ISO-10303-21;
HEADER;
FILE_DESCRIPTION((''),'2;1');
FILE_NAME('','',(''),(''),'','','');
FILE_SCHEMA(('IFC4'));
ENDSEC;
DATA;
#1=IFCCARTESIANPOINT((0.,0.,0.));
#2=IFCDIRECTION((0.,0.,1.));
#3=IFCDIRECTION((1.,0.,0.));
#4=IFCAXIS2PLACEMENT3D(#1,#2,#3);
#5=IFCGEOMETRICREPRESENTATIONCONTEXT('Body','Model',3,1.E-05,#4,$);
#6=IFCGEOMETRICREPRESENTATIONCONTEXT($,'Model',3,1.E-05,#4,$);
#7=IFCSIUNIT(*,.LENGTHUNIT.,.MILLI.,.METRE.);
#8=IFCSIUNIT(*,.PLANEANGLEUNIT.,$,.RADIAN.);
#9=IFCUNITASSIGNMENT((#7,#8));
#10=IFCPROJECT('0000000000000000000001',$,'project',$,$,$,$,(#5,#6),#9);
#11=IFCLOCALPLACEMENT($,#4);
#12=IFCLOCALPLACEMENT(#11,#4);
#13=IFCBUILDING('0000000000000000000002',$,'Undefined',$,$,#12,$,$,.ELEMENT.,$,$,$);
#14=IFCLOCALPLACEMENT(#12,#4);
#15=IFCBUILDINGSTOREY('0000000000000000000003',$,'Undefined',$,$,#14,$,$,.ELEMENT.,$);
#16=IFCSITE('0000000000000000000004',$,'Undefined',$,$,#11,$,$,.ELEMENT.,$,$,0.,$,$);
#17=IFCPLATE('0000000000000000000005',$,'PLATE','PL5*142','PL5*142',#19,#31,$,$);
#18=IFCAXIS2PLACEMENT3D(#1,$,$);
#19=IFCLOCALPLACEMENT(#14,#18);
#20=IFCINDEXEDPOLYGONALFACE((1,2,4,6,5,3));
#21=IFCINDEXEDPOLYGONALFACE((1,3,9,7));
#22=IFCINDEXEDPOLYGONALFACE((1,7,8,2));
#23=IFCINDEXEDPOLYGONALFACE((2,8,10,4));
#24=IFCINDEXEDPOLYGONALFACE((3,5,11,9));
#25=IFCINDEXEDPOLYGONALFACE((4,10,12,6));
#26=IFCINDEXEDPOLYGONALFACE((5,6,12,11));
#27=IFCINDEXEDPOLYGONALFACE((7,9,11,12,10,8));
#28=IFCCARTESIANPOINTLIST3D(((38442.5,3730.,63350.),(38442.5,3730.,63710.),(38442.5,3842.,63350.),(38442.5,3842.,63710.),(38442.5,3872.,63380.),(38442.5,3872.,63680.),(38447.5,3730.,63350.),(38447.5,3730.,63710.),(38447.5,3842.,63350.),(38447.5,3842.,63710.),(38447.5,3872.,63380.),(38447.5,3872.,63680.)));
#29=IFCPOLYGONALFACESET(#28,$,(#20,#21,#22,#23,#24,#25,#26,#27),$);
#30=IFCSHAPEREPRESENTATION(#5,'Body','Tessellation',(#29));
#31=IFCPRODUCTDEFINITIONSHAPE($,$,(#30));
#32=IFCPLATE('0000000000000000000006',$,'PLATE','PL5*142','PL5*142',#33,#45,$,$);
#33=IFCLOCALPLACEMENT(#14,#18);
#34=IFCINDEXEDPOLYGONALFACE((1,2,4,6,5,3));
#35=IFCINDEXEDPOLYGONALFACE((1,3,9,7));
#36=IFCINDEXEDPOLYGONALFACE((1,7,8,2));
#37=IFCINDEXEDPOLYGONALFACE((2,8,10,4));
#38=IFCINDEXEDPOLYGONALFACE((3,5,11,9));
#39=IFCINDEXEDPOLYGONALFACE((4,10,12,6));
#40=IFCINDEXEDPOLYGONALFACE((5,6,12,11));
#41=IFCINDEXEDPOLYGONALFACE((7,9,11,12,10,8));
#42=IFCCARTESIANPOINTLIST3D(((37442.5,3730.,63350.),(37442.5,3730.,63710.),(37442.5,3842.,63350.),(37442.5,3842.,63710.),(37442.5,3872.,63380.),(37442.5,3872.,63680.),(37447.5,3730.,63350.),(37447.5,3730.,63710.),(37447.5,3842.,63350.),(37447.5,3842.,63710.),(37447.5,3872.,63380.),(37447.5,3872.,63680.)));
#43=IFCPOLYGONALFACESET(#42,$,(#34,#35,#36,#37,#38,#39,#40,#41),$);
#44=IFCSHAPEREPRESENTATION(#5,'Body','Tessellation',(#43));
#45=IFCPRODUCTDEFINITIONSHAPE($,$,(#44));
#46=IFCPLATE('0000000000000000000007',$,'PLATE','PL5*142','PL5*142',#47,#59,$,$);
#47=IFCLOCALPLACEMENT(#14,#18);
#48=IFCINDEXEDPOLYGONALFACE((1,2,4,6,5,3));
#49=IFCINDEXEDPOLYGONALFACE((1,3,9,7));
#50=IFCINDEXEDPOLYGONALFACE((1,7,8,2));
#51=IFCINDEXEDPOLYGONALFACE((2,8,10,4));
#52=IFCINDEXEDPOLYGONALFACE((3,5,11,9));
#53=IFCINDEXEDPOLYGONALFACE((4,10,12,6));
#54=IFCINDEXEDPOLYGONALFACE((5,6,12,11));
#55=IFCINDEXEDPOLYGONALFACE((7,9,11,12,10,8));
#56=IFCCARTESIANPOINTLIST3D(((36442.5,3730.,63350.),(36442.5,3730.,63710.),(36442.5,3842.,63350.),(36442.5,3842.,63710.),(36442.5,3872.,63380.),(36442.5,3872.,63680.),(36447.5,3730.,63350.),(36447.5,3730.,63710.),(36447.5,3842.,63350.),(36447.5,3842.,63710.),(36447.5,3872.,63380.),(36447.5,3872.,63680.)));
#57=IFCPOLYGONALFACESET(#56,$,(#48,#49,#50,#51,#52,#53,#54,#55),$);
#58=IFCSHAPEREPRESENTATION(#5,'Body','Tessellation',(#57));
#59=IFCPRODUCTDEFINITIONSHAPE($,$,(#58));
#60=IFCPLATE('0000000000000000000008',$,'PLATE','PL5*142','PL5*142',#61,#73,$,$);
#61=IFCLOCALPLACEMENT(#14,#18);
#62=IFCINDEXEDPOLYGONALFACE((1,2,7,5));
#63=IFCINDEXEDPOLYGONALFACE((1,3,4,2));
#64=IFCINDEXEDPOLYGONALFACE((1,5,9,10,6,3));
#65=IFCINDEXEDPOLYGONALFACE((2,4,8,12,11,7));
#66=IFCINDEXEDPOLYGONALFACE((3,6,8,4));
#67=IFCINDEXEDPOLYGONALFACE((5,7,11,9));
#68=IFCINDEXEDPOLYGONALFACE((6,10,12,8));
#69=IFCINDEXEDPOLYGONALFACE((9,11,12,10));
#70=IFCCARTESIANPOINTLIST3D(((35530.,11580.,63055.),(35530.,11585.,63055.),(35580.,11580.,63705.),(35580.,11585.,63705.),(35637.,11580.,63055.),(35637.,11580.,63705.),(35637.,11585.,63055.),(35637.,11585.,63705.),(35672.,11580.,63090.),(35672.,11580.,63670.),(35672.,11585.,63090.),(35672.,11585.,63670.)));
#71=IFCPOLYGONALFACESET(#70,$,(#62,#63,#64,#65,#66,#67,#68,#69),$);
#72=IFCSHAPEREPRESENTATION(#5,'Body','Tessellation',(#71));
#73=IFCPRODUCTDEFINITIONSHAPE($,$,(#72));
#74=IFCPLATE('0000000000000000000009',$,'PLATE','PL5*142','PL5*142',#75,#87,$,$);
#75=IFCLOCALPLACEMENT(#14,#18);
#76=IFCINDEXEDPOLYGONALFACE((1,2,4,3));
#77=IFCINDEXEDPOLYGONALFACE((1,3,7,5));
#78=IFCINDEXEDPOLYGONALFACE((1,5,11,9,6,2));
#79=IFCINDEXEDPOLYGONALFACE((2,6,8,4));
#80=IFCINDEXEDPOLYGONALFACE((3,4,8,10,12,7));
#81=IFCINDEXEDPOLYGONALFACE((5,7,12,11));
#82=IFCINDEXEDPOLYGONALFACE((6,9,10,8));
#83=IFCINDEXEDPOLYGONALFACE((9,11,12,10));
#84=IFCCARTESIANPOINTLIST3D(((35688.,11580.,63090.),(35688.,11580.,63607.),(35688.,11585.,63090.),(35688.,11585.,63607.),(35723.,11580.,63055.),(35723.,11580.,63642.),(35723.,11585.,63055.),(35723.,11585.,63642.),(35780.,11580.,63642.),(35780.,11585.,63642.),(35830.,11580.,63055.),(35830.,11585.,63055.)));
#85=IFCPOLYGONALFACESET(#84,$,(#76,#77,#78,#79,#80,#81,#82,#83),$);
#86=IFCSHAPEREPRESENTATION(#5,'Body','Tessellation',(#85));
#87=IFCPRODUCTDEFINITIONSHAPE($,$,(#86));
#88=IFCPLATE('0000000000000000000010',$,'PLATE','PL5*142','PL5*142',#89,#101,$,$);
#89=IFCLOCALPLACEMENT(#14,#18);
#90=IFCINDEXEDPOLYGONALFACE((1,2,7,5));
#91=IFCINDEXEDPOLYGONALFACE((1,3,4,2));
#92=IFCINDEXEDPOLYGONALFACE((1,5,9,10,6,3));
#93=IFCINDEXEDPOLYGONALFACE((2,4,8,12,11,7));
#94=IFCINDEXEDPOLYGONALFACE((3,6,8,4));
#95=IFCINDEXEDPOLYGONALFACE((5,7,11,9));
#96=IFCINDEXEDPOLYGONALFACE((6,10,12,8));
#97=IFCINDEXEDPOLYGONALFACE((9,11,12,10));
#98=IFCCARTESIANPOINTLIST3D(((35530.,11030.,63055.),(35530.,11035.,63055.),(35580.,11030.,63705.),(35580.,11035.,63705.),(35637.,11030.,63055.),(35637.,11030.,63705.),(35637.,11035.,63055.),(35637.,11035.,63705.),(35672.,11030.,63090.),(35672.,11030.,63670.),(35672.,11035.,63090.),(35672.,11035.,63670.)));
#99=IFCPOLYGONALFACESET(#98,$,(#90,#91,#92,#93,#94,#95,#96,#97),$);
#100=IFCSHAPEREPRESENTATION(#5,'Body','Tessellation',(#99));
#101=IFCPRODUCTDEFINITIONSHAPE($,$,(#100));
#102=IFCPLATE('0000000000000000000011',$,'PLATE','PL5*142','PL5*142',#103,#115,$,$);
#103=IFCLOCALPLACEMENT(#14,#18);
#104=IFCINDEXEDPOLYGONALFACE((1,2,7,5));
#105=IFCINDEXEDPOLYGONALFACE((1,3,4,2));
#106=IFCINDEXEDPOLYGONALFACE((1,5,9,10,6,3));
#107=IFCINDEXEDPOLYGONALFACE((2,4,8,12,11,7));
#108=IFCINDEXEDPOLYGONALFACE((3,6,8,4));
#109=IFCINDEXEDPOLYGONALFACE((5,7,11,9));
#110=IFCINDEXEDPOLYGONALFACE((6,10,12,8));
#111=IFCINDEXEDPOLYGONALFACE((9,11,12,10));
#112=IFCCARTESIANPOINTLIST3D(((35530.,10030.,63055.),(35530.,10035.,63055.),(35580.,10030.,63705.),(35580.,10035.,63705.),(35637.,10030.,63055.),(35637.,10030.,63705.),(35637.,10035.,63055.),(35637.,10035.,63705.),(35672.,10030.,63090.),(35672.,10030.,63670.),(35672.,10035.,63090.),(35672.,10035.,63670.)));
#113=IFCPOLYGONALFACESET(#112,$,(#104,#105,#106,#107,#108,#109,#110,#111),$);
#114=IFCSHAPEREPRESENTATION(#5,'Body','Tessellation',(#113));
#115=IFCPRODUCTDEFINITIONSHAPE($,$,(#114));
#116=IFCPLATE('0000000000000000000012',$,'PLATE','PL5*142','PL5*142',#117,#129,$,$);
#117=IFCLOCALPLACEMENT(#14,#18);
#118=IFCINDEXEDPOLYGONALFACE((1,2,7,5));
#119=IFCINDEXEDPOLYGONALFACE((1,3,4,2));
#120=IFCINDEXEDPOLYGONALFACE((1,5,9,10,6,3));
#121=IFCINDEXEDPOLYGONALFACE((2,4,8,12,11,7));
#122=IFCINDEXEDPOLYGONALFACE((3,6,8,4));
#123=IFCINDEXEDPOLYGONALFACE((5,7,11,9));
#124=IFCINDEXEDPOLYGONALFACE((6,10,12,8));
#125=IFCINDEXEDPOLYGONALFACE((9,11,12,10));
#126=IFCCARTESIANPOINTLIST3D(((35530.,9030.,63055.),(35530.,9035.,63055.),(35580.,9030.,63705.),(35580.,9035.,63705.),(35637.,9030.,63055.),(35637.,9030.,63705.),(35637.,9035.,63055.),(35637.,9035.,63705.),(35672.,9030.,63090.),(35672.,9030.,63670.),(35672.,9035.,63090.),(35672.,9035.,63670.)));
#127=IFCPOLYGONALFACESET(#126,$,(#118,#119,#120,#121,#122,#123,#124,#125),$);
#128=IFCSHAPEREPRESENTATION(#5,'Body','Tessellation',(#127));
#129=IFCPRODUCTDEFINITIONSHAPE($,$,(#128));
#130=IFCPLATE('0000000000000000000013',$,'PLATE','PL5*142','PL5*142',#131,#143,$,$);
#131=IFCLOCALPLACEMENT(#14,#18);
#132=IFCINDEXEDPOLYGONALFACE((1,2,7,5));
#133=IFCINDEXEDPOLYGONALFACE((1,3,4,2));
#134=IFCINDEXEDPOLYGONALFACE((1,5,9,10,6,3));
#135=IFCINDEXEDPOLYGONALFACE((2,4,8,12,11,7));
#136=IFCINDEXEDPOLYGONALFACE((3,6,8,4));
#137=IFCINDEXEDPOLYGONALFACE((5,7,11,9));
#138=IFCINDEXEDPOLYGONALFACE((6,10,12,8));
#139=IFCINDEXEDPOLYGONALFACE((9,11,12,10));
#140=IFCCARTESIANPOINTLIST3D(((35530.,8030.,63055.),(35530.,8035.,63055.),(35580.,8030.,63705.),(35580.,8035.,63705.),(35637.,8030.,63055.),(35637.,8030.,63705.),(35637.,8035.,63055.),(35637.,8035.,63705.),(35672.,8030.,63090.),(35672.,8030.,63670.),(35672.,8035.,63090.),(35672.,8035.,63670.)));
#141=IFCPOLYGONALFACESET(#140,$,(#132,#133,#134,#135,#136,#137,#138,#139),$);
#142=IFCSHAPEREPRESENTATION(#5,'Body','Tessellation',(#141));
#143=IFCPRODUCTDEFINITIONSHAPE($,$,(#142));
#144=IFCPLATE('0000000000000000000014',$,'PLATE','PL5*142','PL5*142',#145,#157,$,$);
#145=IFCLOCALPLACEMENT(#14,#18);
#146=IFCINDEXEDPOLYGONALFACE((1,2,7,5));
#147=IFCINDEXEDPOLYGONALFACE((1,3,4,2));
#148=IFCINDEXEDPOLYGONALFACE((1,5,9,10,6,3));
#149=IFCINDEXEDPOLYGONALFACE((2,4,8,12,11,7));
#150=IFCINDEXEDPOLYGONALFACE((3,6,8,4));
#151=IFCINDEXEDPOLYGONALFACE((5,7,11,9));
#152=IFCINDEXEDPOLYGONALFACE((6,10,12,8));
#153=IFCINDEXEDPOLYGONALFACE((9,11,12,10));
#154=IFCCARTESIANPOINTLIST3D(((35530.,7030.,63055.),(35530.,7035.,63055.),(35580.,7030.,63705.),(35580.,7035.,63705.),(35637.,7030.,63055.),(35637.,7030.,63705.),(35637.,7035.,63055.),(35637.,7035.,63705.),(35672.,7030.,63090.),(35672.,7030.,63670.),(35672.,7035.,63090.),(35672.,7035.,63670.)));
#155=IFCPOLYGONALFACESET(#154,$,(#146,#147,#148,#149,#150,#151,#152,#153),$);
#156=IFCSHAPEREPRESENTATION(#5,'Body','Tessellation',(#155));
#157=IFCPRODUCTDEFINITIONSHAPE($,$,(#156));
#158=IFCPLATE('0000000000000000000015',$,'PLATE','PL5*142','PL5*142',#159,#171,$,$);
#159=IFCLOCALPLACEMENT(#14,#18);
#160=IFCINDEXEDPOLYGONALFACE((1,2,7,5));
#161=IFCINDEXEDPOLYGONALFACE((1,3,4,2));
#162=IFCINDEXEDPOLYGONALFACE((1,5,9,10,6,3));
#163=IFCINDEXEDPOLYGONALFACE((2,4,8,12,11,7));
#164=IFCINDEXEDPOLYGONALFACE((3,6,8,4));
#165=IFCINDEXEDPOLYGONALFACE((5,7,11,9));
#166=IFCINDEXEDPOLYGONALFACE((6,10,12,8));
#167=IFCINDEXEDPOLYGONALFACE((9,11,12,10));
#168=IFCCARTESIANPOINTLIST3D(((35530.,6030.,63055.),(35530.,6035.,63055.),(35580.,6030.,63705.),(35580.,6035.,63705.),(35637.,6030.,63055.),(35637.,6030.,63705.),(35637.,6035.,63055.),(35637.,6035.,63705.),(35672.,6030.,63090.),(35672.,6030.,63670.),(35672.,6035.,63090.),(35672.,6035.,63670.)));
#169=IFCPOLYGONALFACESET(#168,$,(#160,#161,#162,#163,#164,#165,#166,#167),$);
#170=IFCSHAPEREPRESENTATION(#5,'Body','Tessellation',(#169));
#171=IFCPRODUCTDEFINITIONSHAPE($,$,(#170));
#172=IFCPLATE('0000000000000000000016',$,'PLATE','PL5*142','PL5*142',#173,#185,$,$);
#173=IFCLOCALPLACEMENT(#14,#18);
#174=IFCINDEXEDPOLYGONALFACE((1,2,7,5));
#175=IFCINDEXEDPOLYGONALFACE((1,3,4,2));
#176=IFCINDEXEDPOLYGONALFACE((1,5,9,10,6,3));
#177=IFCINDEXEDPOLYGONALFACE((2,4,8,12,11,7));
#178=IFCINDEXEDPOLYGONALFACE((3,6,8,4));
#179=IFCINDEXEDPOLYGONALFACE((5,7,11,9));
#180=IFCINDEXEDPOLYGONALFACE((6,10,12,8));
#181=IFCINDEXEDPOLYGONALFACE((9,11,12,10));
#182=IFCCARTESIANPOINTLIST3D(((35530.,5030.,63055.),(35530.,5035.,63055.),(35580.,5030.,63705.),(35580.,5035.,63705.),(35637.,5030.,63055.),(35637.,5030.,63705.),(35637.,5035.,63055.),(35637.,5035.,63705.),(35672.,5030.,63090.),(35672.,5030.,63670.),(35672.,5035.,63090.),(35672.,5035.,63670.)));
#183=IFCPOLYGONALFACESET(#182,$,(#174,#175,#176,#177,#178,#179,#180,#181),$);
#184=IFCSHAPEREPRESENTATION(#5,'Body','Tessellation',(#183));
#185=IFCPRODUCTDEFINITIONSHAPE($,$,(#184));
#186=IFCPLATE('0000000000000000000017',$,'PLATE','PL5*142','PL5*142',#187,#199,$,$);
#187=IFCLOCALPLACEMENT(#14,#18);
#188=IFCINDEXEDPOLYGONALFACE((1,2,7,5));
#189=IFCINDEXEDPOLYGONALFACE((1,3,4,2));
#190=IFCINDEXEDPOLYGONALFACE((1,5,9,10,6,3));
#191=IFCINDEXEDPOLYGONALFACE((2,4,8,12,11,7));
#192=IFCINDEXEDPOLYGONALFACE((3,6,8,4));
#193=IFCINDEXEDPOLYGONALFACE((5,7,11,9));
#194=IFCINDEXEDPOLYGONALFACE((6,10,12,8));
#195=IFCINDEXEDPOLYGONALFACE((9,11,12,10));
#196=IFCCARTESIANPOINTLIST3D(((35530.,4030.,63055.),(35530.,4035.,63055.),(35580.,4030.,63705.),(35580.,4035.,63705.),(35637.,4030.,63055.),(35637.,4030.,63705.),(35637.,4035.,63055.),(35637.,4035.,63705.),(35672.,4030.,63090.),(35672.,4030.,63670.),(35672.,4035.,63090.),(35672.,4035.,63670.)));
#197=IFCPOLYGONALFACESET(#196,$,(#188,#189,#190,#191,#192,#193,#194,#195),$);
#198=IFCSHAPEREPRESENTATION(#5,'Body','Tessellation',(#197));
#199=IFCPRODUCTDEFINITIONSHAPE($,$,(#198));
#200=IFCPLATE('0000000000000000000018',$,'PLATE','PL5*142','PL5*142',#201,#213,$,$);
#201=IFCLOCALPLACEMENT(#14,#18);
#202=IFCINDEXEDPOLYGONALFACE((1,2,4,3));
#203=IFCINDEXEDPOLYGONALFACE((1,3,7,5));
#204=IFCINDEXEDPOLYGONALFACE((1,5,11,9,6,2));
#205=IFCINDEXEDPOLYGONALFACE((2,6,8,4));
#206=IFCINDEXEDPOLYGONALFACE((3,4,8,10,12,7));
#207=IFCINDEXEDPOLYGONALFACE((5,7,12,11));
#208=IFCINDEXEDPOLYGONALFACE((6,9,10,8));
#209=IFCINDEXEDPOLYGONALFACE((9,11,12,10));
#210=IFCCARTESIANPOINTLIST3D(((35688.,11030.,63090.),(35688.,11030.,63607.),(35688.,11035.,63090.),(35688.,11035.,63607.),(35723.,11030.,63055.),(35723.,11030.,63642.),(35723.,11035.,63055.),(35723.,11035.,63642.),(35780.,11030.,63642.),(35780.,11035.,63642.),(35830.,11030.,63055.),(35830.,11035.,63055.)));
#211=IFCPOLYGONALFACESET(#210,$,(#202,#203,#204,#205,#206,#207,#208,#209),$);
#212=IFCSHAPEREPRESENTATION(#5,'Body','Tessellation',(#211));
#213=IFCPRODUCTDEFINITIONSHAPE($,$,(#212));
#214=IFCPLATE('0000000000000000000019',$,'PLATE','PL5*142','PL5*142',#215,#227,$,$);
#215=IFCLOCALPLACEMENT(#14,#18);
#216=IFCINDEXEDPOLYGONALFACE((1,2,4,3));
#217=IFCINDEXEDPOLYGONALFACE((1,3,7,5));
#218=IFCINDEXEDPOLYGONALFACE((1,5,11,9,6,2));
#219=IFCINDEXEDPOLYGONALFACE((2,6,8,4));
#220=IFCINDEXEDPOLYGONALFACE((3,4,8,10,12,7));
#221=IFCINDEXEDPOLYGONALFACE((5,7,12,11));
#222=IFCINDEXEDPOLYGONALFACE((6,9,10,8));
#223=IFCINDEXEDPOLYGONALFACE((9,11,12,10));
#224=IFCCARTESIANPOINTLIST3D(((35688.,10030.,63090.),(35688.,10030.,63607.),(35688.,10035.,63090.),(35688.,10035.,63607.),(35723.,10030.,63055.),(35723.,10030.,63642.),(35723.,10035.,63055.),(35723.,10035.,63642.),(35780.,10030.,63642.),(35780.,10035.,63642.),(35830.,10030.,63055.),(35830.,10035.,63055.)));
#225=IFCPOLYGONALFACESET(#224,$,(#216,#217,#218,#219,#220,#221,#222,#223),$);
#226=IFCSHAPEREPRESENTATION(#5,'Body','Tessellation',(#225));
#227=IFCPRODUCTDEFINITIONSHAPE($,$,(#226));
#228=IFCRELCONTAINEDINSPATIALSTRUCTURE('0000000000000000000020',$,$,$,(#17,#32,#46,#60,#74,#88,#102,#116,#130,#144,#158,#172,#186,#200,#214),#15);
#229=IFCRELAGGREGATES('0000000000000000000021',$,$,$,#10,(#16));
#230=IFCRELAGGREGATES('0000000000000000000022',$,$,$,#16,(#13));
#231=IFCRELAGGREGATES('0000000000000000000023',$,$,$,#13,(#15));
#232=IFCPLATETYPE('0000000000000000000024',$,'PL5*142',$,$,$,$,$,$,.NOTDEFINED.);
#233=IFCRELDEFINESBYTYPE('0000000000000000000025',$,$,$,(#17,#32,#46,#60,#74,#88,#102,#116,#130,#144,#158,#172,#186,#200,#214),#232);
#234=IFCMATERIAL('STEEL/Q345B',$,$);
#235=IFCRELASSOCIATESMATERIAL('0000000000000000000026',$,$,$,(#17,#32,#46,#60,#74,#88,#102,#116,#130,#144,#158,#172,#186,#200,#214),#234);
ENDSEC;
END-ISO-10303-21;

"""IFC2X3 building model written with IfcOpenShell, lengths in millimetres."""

from ifc_helpers import new_model, si_unit, frame, origin_with_axes, place, context, project, spatial, polyline, outline, extrude, material, type_object, element, save


model = new_model("IFC2X3")

# Units and contexts
model_context_1 = context("Model", 3, precision=1e-05, world=origin_with_axes(), identifier="Body")
model_context_2 = context("Model", 3, precision=1e-05, world=origin_with_axes())
ifc_project = project(units=[si_unit("LENGTHUNIT", "METRE", prefix="MILLI"), si_unit("PLANEANGLEUNIT", "RADIAN")], contexts=[model_context_1, model_context_2])

# Site, building, storey
site_placement = place(None, origin_with_axes())
site = spatial("IfcSite", under=ifc_project, at=site_placement, Name="Undefined", CompositionType="ELEMENT", RefElevation=0.0)
building_placement = place(site_placement, origin_with_axes())
building = spatial("IfcBuilding", under=site, at=building_placement, Name="Undefined", CompositionType="ELEMENT")
storey_placement = place(building_placement, origin_with_axes())
storey = spatial("IfcBuildingStorey", under=building, at=storey_placement, Name="Undefined", CompositionType="ELEMENT")

# Shared definitions
ifc_material_1 = material(Name="STEEL/Q345B")

# Plates
plate_type_1 = type_object("IfcPlateType", Name="PL5*142", PredefinedType="NOTDEFINED")
for number, where, z_axis, x_axis, name in (
    (1, (38445.0, 3730.0, 63710.0), (-1.0, 0.0, 0.0), (0.0, 1.0, 0.0), "PLATE"),
    (2, (37445.0, 3730.0, 63710.0), (-1.0, 0.0, 0.0), (0.0, 1.0, 0.0), "PLATE"),
    (3, (36445.0, 3730.0, 63710.0), (-1.0, 0.0, 0.0), (0.0, 1.0, 0.0), "PLATE"),
):
    element("IfcPlate", number, at=place(storey_placement, frame(where, z_axis=z_axis, x_axis=x_axis)), inside=storey, type_object=plate_type_1, material=ifc_material_1, Name=name, Description="PL5*142", ObjectType="PL5*142", context=model_context_1, shape_type="SweptSolid", body=[
        extrude(outline(polyline([(0.0, 0.0), (112.0, 0.0), (142.0, 30.0), (142.0, 330.0), (112.0, 360.0), (0.0, 360.0), (0.0, 0.0)])), frame((0.0, 0.0, -2.5), z_axis=(0.0, 0.0, 1.0), x_axis=(1.0, 0.0, 0.0)), (0.0, 0.0, 1.0), 5.0),
    ])
plate_1_placement = place(storey_placement, frame((35530.0, 11582.5, 63055.0), z_axis=(0.0, -1.0, 0.0), x_axis=(1.0, 0.0, 0.0)))
element("IfcPlate", 4, at=plate_1_placement, inside=storey, type_object=plate_type_1, material=ifc_material_1, Name="PLATE", Description="PL5*142", ObjectType="PL5*142", context=model_context_1, shape_type="SweptSolid", body=[
    extrude(outline(polyline([(0.0, 0.0), (107.0, 0.0), (142.0, 35.0), (142.0, 615.0), (107.0, 650.0), (50.0, 650.0), (0.0, 0.0)])), frame((0.0, 0.0, -2.5), z_axis=(0.0, 0.0, 1.0), x_axis=(1.0, 0.0, 0.0)), (0.0, 0.0, 1.0), 5.0),
])
plate_2_placement = place(storey_placement, frame((35688.0, 11582.5, 63642.0), z_axis=(0.0, 1.0, 0.0), x_axis=(1.0, 0.0, 0.0)))
element("IfcPlate", 5, at=plate_2_placement, inside=storey, type_object=plate_type_1, material=ifc_material_1, Name="PLATE", Description="PL5*142", ObjectType="PL5*142", context=model_context_1, shape_type="SweptSolid", body=[
    extrude(outline(polyline([(0.0, 35.0), (35.0, 0.0), (92.0, 0.0), (142.0, 587.0), (35.0, 587.0), (0.0, 552.0), (0.0, 35.0)])), frame((0.0, 0.0, -2.5), z_axis=(0.0, 0.0, 1.0), x_axis=(1.0, 0.0, 0.0)), (0.0, 0.0, 1.0), 5.0),
])
for number, where, z_axis, x_axis, name in (
    (6, (35530.0, 11032.5, 63055.0), (0.0, -1.0, 0.0), (1.0, 0.0, 0.0), "PLATE"),
    (7, (35530.0, 10032.5, 63055.0), (0.0, -1.0, 0.0), (1.0, 0.0, 0.0), "PLATE"),
    (8, (35530.0, 9032.5, 63055.0), (0.0, -1.0, 0.0), (1.0, 0.0, 0.0), "PLATE"),
    (9, (35530.0, 8032.5, 63055.0), (0.0, -1.0, 0.0), (1.0, 0.0, 0.0), "PLATE"),
    (10, (35530.0, 7032.5, 63055.0), (0.0, -1.0, 0.0), (1.0, 0.0, 0.0), "PLATE"),
    (11, (35530.0, 6032.5, 63055.0), (0.0, -1.0, 0.0), (1.0, 0.0, 0.0), "PLATE"),
    (12, (35530.0, 5032.5, 63055.0), (0.0, -1.0, 0.0), (1.0, 0.0, 0.0), "PLATE"),
    (13, (35530.0, 4032.5, 63055.0), (0.0, -1.0, 0.0), (1.0, 0.0, 0.0), "PLATE"),
):
    element("IfcPlate", number, at=place(storey_placement, frame(where, z_axis=z_axis, x_axis=x_axis)), inside=storey, type_object=plate_type_1, material=ifc_material_1, Name=name, Description="PL5*142", ObjectType="PL5*142", context=model_context_1, shape_type="SweptSolid", body=[
        extrude(outline(polyline([(0.0, 0.0), (107.0, 0.0), (142.0, 35.0), (142.0, 615.0), (107.0, 650.0), (50.0, 650.0), (0.0, 0.0)])), frame((0.0, 0.0, -2.5), z_axis=(0.0, 0.0, 1.0), x_axis=(1.0, 0.0, 0.0)), (0.0, 0.0, 1.0), 5.0),
    ])
for number, where, z_axis, x_axis, name in (
    (14, (35688.0, 11032.5, 63642.0), (0.0, 1.0, 0.0), (1.0, 0.0, 0.0), "PLATE"),
    (15, (35688.0, 10032.5, 63642.0), (0.0, 1.0, 0.0), (1.0, 0.0, 0.0), "PLATE"),
):
    element("IfcPlate", number, at=place(storey_placement, frame(where, z_axis=z_axis, x_axis=x_axis)), inside=storey, type_object=plate_type_1, material=ifc_material_1, Name=name, Description="PL5*142", ObjectType="PL5*142", context=model_context_1, shape_type="SweptSolid", body=[
        extrude(outline(polyline([(0.0, 35.0), (35.0, 0.0), (92.0, 0.0), (142.0, 587.0), (35.0, 587.0), (0.0, 552.0), (0.0, 35.0)])), frame((0.0, 0.0, -2.5), z_axis=(0.0, 0.0, 1.0), x_axis=(1.0, 0.0, 0.0)), (0.0, 0.0, 1.0), 5.0),
    ])

save(model, "model.ifc")
